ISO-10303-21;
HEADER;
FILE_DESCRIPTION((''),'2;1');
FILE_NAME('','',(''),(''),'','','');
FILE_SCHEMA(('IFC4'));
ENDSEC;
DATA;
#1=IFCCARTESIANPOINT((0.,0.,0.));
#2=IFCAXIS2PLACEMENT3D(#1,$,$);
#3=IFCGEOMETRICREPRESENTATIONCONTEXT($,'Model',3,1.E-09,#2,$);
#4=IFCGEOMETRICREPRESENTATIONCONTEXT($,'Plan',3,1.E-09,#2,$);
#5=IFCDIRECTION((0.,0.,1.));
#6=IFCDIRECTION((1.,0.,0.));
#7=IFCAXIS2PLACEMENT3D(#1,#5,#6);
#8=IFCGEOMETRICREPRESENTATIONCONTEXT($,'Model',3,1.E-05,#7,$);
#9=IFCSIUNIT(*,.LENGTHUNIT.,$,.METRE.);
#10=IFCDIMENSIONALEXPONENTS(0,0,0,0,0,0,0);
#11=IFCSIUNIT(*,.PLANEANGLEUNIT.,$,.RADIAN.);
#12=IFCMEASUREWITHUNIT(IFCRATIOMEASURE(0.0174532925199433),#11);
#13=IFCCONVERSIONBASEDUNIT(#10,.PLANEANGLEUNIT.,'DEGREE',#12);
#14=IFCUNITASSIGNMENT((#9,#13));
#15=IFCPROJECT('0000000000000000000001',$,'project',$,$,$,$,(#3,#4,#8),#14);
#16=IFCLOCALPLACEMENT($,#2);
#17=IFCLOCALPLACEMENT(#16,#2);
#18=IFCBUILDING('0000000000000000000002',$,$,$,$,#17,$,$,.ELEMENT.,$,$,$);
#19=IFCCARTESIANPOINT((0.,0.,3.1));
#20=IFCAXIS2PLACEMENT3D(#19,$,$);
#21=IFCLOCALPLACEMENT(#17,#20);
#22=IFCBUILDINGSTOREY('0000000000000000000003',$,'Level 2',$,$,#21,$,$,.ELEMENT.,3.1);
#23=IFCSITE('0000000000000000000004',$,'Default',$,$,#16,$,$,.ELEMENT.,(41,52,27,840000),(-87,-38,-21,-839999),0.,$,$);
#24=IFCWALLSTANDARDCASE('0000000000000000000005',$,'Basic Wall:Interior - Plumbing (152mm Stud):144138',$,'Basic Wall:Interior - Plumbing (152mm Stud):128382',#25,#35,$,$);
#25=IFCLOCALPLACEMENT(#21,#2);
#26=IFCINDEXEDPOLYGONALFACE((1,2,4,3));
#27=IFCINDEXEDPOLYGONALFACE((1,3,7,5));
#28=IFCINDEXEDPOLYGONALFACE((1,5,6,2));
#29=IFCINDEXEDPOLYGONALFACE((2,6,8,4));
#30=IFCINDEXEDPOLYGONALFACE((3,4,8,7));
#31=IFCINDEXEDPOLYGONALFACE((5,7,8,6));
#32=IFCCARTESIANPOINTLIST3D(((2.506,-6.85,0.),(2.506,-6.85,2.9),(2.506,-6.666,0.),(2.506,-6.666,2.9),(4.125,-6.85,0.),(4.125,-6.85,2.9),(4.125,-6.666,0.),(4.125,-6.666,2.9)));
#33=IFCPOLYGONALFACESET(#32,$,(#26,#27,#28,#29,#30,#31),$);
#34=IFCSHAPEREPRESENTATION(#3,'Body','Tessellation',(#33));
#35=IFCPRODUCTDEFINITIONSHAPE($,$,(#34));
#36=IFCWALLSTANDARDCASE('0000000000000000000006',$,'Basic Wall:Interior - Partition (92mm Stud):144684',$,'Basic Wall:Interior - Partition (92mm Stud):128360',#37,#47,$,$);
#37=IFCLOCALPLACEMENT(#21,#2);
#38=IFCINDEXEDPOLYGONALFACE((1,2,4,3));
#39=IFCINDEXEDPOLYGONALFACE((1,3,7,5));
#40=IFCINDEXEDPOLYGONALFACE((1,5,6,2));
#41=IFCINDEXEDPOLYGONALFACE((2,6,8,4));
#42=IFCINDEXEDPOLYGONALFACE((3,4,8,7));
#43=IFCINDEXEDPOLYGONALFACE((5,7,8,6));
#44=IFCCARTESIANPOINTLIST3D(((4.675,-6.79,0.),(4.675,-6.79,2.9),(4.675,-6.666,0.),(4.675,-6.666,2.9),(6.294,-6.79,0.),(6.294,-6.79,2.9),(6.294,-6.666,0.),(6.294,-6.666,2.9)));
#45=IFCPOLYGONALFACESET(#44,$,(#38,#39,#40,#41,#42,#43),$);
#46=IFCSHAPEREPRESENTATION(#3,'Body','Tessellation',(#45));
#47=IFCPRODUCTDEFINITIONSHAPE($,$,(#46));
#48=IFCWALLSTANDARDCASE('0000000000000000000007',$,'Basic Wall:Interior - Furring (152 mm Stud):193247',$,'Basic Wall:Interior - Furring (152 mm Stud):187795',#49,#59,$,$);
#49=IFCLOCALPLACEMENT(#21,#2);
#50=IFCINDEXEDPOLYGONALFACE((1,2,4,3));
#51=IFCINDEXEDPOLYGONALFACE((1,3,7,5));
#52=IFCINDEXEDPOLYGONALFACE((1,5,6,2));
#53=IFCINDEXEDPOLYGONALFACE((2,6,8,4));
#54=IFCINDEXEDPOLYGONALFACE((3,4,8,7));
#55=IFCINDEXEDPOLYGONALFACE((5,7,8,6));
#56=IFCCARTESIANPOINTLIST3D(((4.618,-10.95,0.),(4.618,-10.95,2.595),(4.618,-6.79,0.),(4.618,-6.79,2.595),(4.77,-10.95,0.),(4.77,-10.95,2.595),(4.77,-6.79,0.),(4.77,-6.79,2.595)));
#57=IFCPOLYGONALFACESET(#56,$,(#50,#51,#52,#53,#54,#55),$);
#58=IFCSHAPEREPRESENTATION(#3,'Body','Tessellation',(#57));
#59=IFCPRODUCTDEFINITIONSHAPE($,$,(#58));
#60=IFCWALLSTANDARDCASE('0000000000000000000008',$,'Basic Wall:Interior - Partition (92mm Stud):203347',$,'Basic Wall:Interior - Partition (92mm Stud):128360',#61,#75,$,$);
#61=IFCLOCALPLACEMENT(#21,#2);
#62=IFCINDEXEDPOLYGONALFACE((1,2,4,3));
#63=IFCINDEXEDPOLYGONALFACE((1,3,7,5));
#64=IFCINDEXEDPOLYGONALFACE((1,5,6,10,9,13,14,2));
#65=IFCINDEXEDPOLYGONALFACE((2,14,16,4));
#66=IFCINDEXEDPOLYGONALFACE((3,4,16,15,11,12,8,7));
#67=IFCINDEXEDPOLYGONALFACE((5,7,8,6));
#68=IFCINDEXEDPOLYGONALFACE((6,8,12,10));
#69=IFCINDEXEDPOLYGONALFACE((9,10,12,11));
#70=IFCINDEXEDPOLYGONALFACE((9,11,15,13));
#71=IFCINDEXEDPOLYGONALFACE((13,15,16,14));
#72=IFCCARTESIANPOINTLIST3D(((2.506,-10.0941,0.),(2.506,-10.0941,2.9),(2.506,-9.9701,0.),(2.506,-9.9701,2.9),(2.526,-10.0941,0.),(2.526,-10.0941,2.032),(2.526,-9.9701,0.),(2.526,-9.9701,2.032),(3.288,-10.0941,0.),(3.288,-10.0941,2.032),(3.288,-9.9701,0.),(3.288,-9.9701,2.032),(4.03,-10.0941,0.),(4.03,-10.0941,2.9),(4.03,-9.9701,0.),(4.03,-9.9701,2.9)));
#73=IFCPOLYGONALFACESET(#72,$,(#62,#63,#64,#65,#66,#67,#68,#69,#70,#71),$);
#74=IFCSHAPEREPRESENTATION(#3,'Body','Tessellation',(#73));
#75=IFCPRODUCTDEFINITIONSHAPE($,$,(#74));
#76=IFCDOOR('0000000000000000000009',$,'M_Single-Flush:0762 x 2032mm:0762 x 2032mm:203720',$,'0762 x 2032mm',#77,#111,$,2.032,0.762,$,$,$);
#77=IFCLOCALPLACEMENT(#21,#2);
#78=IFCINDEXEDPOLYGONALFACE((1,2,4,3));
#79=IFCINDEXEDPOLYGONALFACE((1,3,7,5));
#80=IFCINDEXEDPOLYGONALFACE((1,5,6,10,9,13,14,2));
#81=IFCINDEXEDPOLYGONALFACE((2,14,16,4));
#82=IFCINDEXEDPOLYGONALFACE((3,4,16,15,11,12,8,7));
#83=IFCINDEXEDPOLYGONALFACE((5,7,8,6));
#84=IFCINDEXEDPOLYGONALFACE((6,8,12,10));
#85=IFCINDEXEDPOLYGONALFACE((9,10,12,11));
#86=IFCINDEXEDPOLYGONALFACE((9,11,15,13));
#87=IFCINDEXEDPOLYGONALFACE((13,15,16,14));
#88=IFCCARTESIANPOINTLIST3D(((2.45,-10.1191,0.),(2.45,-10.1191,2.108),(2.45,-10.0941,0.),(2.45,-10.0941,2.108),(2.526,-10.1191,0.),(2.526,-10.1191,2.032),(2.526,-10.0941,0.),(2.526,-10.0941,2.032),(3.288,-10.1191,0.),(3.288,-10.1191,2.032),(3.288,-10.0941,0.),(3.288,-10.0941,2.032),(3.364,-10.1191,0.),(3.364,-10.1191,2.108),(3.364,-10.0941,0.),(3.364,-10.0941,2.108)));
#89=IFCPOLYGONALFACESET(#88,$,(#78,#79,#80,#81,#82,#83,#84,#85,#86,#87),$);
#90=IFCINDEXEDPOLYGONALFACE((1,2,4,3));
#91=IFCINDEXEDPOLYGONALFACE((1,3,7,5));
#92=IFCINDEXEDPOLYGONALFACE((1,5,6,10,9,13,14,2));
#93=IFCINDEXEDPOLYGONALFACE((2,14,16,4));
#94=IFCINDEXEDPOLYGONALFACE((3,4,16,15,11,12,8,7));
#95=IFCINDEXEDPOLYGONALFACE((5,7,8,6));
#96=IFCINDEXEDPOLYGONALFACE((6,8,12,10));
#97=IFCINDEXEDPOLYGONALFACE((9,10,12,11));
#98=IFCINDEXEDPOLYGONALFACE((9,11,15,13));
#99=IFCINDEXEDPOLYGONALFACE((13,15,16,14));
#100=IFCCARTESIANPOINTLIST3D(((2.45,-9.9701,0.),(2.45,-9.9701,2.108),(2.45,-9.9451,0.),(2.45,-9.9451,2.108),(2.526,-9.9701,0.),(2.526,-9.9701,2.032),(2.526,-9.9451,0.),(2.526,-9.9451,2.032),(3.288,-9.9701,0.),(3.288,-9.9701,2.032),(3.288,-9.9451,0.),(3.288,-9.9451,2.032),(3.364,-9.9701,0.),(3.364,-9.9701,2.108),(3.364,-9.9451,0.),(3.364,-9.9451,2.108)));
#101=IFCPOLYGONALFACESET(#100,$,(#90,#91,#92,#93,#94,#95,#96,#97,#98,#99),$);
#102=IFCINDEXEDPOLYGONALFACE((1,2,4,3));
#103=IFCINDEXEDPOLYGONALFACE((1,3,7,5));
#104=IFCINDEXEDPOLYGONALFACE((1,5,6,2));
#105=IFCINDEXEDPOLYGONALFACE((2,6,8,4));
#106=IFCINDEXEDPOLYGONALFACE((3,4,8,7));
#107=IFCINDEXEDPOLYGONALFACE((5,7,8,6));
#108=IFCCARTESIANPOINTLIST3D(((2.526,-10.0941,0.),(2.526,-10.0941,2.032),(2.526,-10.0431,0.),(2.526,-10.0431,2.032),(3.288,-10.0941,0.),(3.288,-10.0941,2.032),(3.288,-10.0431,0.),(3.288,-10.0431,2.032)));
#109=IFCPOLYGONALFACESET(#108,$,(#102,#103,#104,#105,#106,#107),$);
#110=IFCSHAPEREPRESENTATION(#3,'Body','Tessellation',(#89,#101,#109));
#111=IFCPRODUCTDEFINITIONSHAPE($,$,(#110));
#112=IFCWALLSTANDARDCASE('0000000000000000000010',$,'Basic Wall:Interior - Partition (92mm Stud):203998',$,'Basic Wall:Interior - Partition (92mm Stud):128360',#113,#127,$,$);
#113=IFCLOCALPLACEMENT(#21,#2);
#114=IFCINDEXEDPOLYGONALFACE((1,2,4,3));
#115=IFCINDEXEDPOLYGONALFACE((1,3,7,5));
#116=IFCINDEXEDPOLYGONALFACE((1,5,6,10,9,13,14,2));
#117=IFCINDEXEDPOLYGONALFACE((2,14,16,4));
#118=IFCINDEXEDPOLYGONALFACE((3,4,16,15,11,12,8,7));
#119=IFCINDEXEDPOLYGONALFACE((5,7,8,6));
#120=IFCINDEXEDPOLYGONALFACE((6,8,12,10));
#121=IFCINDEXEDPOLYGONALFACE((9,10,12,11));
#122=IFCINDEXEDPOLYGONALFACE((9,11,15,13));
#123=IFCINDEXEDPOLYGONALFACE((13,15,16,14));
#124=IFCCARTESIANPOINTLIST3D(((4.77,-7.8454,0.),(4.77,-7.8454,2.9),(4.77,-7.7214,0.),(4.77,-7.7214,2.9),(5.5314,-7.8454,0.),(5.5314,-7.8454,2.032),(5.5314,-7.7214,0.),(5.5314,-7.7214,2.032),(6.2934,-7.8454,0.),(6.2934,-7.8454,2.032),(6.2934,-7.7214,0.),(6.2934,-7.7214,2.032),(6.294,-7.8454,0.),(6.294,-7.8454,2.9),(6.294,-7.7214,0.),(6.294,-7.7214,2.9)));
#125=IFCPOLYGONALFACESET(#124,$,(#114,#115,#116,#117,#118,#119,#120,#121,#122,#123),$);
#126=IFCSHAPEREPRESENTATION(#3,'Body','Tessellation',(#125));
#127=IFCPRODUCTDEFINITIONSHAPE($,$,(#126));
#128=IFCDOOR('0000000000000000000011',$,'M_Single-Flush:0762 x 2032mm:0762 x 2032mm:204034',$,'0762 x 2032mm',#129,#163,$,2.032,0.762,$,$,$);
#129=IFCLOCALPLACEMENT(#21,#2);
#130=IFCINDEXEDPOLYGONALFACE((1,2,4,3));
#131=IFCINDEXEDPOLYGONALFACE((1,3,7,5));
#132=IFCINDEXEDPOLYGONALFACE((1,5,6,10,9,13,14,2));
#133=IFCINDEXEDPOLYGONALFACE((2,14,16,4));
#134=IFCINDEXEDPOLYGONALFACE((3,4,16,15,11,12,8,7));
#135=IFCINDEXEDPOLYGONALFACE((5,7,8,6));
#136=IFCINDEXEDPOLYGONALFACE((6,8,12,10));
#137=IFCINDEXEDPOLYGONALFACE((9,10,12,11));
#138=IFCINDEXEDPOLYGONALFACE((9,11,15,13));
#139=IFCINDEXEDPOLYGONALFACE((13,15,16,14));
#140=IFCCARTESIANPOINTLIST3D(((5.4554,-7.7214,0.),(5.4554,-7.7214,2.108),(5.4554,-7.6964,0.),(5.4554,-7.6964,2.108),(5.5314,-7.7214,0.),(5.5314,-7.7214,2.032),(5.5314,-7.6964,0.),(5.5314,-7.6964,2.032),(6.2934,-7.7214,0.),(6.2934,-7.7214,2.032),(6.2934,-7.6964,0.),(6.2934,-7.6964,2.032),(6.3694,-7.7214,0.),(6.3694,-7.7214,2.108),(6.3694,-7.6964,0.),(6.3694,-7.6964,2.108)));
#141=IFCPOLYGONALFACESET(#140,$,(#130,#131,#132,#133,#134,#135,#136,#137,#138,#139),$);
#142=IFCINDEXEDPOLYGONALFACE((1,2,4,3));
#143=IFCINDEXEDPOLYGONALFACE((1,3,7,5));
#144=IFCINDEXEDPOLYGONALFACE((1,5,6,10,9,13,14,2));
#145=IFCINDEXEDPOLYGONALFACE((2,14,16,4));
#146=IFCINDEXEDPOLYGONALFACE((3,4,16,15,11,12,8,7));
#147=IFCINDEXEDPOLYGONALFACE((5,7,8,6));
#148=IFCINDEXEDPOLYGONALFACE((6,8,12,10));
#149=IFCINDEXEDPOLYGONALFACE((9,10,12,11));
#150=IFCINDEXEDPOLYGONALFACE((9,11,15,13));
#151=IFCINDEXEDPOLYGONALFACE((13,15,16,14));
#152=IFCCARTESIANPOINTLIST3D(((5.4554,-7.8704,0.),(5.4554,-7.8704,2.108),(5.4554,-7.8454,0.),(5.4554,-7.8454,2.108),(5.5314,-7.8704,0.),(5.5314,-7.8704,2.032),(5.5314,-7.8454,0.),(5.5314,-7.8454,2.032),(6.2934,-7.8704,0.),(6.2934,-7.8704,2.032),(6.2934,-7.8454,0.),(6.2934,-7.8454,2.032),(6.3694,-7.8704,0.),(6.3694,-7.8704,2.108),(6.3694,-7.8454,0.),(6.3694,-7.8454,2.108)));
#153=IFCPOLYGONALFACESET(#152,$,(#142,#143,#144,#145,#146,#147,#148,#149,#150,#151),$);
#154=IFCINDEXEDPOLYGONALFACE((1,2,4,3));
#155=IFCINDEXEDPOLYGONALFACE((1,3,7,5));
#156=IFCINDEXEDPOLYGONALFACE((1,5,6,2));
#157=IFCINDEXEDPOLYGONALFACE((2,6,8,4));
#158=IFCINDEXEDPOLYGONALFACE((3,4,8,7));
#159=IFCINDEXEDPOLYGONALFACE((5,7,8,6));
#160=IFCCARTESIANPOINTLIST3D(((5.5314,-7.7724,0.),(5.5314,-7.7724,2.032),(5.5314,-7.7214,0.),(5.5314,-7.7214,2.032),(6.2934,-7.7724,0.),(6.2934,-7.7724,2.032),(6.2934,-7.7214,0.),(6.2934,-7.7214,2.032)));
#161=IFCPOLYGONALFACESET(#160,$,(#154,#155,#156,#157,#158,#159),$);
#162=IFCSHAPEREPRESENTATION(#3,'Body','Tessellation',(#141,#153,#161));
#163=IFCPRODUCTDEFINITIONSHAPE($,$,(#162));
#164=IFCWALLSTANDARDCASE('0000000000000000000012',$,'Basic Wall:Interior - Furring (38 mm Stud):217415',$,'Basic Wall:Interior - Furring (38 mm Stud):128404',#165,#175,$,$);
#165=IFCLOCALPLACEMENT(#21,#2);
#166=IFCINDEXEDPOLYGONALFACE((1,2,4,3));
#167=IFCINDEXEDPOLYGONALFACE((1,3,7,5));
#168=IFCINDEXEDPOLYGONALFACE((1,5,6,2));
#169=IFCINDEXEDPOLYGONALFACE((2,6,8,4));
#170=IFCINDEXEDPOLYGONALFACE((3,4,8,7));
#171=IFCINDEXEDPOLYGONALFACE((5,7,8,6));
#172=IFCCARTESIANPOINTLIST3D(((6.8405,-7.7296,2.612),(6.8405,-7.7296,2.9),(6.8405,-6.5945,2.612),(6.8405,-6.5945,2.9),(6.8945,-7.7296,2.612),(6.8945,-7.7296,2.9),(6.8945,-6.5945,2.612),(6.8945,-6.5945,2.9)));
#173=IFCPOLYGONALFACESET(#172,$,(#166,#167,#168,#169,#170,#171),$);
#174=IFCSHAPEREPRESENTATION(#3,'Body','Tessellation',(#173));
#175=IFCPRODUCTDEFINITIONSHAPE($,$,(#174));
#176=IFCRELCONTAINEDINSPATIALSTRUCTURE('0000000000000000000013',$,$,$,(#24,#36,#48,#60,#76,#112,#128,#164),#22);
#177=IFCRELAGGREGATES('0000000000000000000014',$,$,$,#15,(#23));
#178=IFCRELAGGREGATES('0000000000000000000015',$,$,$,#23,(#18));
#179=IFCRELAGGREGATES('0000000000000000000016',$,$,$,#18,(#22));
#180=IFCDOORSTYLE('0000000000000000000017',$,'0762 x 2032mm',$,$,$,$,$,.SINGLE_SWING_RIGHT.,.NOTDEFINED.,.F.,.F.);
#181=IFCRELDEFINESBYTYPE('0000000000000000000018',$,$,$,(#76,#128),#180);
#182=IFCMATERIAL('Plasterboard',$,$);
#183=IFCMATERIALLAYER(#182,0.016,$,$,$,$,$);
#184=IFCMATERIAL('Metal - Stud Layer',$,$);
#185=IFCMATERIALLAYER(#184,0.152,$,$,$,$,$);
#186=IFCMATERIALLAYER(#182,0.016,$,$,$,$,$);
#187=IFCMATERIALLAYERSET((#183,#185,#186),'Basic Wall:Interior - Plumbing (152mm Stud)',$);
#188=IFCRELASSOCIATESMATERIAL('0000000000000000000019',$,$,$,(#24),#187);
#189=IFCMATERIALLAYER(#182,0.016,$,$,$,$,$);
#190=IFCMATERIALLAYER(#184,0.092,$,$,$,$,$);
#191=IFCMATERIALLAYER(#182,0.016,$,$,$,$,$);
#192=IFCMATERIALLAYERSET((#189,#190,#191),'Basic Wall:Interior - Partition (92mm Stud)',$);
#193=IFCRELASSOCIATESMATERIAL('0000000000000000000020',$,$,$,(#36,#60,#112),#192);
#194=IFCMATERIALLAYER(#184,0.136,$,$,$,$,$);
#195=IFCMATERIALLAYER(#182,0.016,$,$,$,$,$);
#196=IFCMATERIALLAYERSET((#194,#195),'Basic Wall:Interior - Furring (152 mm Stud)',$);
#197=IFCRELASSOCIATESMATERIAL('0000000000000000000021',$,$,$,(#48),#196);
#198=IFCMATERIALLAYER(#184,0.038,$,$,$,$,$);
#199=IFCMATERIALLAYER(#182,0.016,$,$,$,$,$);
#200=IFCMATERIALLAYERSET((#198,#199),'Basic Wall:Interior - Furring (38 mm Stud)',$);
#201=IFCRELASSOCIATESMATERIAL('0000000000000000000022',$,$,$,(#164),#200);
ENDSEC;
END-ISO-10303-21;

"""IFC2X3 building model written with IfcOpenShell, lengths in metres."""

from ifc_helpers import new_model, entity, si_unit, converted_unit, frame, frame_2d, origin, origin_with_axes, origin_2d_with_axis, place, context, project, spatial, polyline, rectangle, outline, extrude, source, transform, mapped, material, layer, layer_set, layer_usage, type_object, type_shapes, element, fill, save


model = new_model("IFC2X3")

# Units and contexts
model_context_1 = context("Model", 3, precision=1e-09, world=origin())
plan_context = context("Plan", 3, precision=1e-09, world=origin())
model_context_2 = context("Model", 3, precision=1e-05, world=origin_with_axes())
ifc_project = project(units=[si_unit("LENGTHUNIT", "METRE"), converted_unit("PLANEANGLEUNIT", "DEGREE", entity("IfcRatioMeasure", 0.0174532925199433), si_unit("PLANEANGLEUNIT", "RADIAN"), dimensions=[0, 0, 0, 0, 0, 0, 0])], contexts=[model_context_1, plan_context, model_context_2])

# Site, building, storey
site_placement = place(None, origin())
site = spatial("IfcSite", under=ifc_project, at=site_placement, Name="Default", CompositionType="ELEMENT", RefLatitude=(41, 52, 27, 840000), RefLongitude=(-87, -38, -21, -839999), RefElevation=0.0)
building_placement = place(site_placement, origin())
building = spatial("IfcBuilding", under=site, at=building_placement, CompositionType="ELEMENT")
storey_placement = place(building_placement, frame((0.0, 0.0, 3.1)))
storey = spatial("IfcBuildingStorey", under=building, at=storey_placement, Name="Level 2", CompositionType="ELEMENT", Elevation=3.1)

# Walls
ifc_material_1 = material(Name="Plasterboard")
ifc_layer_1 = layer(ifc_material_1, 0.016)
ifc_material_2 = material(Name="Metal - Stud Layer")
ifc_layer_2 = layer(ifc_material_2, 0.152)
ifc_layer_3 = layer(ifc_material_1, 0.016)
ifc_layer_set_1 = layer_set([ifc_layer_1, ifc_layer_2, ifc_layer_3], Name="Basic Wall:Interior - Plumbing (152mm Stud)")
ifc_layer_usage_1 = layer_usage(ifc_layer_set_1, "AXIS2", "NEGATIVE", 0.092)
wall_1_placement = place(storey_placement, frame((2.506, -6.758, 0.0)))
element("IfcWallStandardCase", 1, at=wall_1_placement, inside=storey, material=ifc_layer_usage_1, Name="Basic Wall:Interior - Plumbing (152mm Stud):144138", ObjectType="Basic Wall:Interior - Plumbing (152mm Stud):128382", context=model_context_1, shape_type="SweptSolid", body=[
    extrude(rectangle(XDim=1.619, YDim=0.184, at=frame_2d((0.8095, 0.0), x_axis=(-1.0, 0.0))), origin(), (0.0, 0.0, 1.0), 2.9),
])
ifc_layer_4 = layer(ifc_material_1, 0.016)
ifc_layer_5 = layer(ifc_material_2, 0.092)
ifc_layer_6 = layer(ifc_material_1, 0.016)
ifc_layer_set_2 = layer_set([ifc_layer_4, ifc_layer_5, ifc_layer_6], Name="Basic Wall:Interior - Partition (92mm Stud)")
ifc_layer_usage_2 = layer_usage(ifc_layer_set_2, "AXIS2", "NEGATIVE", 0.062)
wall_2_placement = place(storey_placement, frame((4.675, -6.728, 0.0)))
element("IfcWallStandardCase", 2, at=wall_2_placement, inside=storey, material=ifc_layer_usage_2, Name="Basic Wall:Interior - Partition (92mm Stud):144684", ObjectType="Basic Wall:Interior - Partition (92mm Stud):128360", context=model_context_1, shape_type="SweptSolid", body=[
    extrude(rectangle(XDim=1.619, YDim=0.124, at=frame_2d((0.8095, 0.0), x_axis=(-1.0, 0.0))), origin(), (0.0, 0.0, 1.0), 2.9),
])
ifc_layer_7 = layer(ifc_material_2, 0.136)
ifc_layer_8 = layer(ifc_material_1, 0.016)
ifc_layer_set_3 = layer_set([ifc_layer_7, ifc_layer_8], Name="Basic Wall:Interior - Furring (152 mm Stud)")
ifc_layer_usage_3 = layer_usage(ifc_layer_set_3, "AXIS2", "POSITIVE", -0.076)
wall_3_placement = place(storey_placement, frame((4.694, -6.79, 0.0), z_axis=(0.0, 0.0, 1.0), x_axis=(0.0, -1.0, 0.0)))
element("IfcWallStandardCase", 3, at=wall_3_placement, inside=storey, material=ifc_layer_usage_3, Name="Basic Wall:Interior - Furring (152 mm Stud):193247", ObjectType="Basic Wall:Interior - Furring (152 mm Stud):187795", context=model_context_1, shape_type="SweptSolid", body=[
    extrude(rectangle(XDim=4.16, YDim=0.152, at=frame_2d((2.08, 0.0), x_axis=(-1.0, 0.0))), origin(), (0.0, 0.0, 1.0), 2.595),
])

# Walls, openings, doors
ifc_layer_usage_4 = layer_usage(ifc_layer_set_2, "AXIS2", "NEGATIVE", 0.062)
wall_4_placement = place(storey_placement, frame((4.03, -10.0321, 0.0), z_axis=(0.0, 0.0, 1.0), x_axis=(-1.0, 0.0, 0.0)))
wall_4 = element("IfcWallStandardCase", 4, at=wall_4_placement, inside=storey, material=ifc_layer_usage_4, Name="Basic Wall:Interior - Partition (92mm Stud):203347", ObjectType="Basic Wall:Interior - Partition (92mm Stud):128360", context=model_context_1, shape_type="SweptSolid", body=[
    extrude(rectangle(XDim=1.524, YDim=0.124, at=frame_2d((0.762, 0.0), x_axis=(-1.0, 0.0))), origin(), (0.0, 0.0, 1.0), 2.9),
])
opening_1_placement = place(wall_4_placement, frame((0.742, -0.062, 0.0)))
opening_1 = element("IfcOpeningElement", 5, at=opening_1_placement, cuts=wall_4, ObjectType="Opening", context=model_context_1, shape_type="SweptSolid", body=[
    extrude(rectangle(XDim=0.762, YDim=2.032, at=frame_2d((1.016, 0.381), x_axis=(0.0, 1.0))), frame((0.0, 0.0, 0.0), z_axis=(0.0, 1.0, 0.0), x_axis=(0.0, 0.0, 1.0)), (0.0, 0.0, 1.0), 0.124),
])
door_style = type_object("IfcDoorStyle", Name="0762 x 2032mm", ConstructionType="NOTDEFINED", OperationType="SINGLE_SWING_RIGHT", ParameterTakesPrecedence=False, Sizeable=False)
shared_shape = source(origin(), model_context_1, "Body", "SweptSolid", [
    extrude(outline(polyline([(-0.457, -1.073), (0.457, -1.073), (0.457, 1.035), (0.381, 1.035), (0.381, -0.997), (-0.381, -0.997), (-0.381, 1.035), (-0.457, 1.035), (-0.457, -1.073)])), frame((0.381, 0.124, 1.035), z_axis=(0.0, 1.0, 0.0), x_axis=(1.0, 0.0, 0.0)), (0.0, 0.0, 1.0), 0.025),
    extrude(outline(polyline([(-1.073, -0.457), (1.035, -0.457), (1.035, -0.381), (-0.997, -0.381), (-0.997, 0.381), (1.035, 0.381), (1.035, 0.457), (-1.073, 0.457), (-1.073, -0.457)])), frame((0.381, -0.025, 1.035), z_axis=(0.0, 1.0, 0.0), x_axis=(0.0, 0.0, -1.0)), (0.0, 0.0, 1.0), 0.025),
    extrude(rectangle(XDim=0.051, YDim=0.762, at=origin_2d_with_axis()), frame((0.381, 0.0985, 0.0), z_axis=(0.0, 0.0, 1.0), x_axis=(0.0, 1.0, 0.0)), (0.0, 0.0, 1.0), 2.032),
])
type_shapes(door_style, [shared_shape])
door_1_placement = place(opening_1_placement, origin())
door_1 = element("IfcDoor", 6, at=door_1_placement, inside=storey, type_object=door_style, Name="M_Single-Flush:0762 x 2032mm:0762 x 2032mm:203720", ObjectType="0762 x 2032mm", OverallHeight=2.032, OverallWidth=0.762, context=model_context_1, shape_type="MappedRepresentation", body=[
    mapped(shared_shape, transform((0.0, 0.0, 0.0), scale=1.0)),
])
fill(opening_1, door_1)
ifc_layer_usage_5 = layer_usage(ifc_layer_set_2, "AXIS2", "POSITIVE", -0.062)
wall_5_placement = place(storey_placement, frame((4.77, -7.7834, 0.0)))
wall_5 = element("IfcWallStandardCase", 7, at=wall_5_placement, inside=storey, material=ifc_layer_usage_5, Name="Basic Wall:Interior - Partition (92mm Stud):203998", ObjectType="Basic Wall:Interior - Partition (92mm Stud):128360", context=model_context_1, shape_type="SweptSolid", body=[
    extrude(rectangle(XDim=1.524, YDim=0.124, at=frame_2d((0.762, 0.0), x_axis=(-1.0, 0.0))), origin(), (0.0, 0.0, 1.0), 2.9),
])
opening_2_placement = place(wall_5_placement, frame((0.7614, -0.062, 0.0)))
opening_2 = element("IfcOpeningElement", 8, at=opening_2_placement, cuts=wall_5, ObjectType="Opening", context=model_context_1, shape_type="SweptSolid", body=[
    extrude(rectangle(XDim=0.762, YDim=2.032, at=frame_2d((1.016, 0.381), x_axis=(0.0, 1.0))), frame((0.0, 0.0, 0.0), z_axis=(0.0, 1.0, 0.0), x_axis=(0.0, 0.0, 1.0)), (0.0, 0.0, 1.0), 0.124),
])
door_2_placement = place(opening_2_placement, origin())
door_2 = element("IfcDoor", 9, at=door_2_placement, inside=storey, type_object=door_style, Name="M_Single-Flush:0762 x 2032mm:0762 x 2032mm:204034", ObjectType="0762 x 2032mm", OverallHeight=2.032, OverallWidth=0.762, context=model_context_1, shape_type="MappedRepresentation", body=[
    mapped(shared_shape, transform((0.0, 0.0, 0.0), scale=1.0)),
])
fill(opening_2, door_2)

# Wall
ifc_layer_9 = layer(ifc_material_2, 0.038)
ifc_layer_10 = layer(ifc_material_1, 0.016)
ifc_layer_set_4 = layer_set([ifc_layer_9, ifc_layer_10], Name="Basic Wall:Interior - Furring (38 mm Stud)")
ifc_layer_usage_6 = layer_usage(ifc_layer_set_4, "AXIS2", "NEGATIVE", 0.027)
wall_6_placement = place(storey_placement, frame((6.8675, -7.7296, 2.612), z_axis=(0.0, 0.0, 1.0), x_axis=(0.0, 1.0, 0.0)))
element("IfcWallStandardCase", 10, at=wall_6_placement, inside=storey, material=ifc_layer_usage_6, Name="Basic Wall:Interior - Furring (38 mm Stud):217415", ObjectType="Basic Wall:Interior - Furring (38 mm Stud):128404", context=model_context_1, shape_type="SweptSolid", body=[
    extrude(rectangle(XDim=1.1351, YDim=0.054, at=frame_2d((0.5675, 0.0), x_axis=(-1.0, 0.0))), origin(), (0.0, 0.0, 1.0), 0.288),
])

save(model, "model.ifc")
